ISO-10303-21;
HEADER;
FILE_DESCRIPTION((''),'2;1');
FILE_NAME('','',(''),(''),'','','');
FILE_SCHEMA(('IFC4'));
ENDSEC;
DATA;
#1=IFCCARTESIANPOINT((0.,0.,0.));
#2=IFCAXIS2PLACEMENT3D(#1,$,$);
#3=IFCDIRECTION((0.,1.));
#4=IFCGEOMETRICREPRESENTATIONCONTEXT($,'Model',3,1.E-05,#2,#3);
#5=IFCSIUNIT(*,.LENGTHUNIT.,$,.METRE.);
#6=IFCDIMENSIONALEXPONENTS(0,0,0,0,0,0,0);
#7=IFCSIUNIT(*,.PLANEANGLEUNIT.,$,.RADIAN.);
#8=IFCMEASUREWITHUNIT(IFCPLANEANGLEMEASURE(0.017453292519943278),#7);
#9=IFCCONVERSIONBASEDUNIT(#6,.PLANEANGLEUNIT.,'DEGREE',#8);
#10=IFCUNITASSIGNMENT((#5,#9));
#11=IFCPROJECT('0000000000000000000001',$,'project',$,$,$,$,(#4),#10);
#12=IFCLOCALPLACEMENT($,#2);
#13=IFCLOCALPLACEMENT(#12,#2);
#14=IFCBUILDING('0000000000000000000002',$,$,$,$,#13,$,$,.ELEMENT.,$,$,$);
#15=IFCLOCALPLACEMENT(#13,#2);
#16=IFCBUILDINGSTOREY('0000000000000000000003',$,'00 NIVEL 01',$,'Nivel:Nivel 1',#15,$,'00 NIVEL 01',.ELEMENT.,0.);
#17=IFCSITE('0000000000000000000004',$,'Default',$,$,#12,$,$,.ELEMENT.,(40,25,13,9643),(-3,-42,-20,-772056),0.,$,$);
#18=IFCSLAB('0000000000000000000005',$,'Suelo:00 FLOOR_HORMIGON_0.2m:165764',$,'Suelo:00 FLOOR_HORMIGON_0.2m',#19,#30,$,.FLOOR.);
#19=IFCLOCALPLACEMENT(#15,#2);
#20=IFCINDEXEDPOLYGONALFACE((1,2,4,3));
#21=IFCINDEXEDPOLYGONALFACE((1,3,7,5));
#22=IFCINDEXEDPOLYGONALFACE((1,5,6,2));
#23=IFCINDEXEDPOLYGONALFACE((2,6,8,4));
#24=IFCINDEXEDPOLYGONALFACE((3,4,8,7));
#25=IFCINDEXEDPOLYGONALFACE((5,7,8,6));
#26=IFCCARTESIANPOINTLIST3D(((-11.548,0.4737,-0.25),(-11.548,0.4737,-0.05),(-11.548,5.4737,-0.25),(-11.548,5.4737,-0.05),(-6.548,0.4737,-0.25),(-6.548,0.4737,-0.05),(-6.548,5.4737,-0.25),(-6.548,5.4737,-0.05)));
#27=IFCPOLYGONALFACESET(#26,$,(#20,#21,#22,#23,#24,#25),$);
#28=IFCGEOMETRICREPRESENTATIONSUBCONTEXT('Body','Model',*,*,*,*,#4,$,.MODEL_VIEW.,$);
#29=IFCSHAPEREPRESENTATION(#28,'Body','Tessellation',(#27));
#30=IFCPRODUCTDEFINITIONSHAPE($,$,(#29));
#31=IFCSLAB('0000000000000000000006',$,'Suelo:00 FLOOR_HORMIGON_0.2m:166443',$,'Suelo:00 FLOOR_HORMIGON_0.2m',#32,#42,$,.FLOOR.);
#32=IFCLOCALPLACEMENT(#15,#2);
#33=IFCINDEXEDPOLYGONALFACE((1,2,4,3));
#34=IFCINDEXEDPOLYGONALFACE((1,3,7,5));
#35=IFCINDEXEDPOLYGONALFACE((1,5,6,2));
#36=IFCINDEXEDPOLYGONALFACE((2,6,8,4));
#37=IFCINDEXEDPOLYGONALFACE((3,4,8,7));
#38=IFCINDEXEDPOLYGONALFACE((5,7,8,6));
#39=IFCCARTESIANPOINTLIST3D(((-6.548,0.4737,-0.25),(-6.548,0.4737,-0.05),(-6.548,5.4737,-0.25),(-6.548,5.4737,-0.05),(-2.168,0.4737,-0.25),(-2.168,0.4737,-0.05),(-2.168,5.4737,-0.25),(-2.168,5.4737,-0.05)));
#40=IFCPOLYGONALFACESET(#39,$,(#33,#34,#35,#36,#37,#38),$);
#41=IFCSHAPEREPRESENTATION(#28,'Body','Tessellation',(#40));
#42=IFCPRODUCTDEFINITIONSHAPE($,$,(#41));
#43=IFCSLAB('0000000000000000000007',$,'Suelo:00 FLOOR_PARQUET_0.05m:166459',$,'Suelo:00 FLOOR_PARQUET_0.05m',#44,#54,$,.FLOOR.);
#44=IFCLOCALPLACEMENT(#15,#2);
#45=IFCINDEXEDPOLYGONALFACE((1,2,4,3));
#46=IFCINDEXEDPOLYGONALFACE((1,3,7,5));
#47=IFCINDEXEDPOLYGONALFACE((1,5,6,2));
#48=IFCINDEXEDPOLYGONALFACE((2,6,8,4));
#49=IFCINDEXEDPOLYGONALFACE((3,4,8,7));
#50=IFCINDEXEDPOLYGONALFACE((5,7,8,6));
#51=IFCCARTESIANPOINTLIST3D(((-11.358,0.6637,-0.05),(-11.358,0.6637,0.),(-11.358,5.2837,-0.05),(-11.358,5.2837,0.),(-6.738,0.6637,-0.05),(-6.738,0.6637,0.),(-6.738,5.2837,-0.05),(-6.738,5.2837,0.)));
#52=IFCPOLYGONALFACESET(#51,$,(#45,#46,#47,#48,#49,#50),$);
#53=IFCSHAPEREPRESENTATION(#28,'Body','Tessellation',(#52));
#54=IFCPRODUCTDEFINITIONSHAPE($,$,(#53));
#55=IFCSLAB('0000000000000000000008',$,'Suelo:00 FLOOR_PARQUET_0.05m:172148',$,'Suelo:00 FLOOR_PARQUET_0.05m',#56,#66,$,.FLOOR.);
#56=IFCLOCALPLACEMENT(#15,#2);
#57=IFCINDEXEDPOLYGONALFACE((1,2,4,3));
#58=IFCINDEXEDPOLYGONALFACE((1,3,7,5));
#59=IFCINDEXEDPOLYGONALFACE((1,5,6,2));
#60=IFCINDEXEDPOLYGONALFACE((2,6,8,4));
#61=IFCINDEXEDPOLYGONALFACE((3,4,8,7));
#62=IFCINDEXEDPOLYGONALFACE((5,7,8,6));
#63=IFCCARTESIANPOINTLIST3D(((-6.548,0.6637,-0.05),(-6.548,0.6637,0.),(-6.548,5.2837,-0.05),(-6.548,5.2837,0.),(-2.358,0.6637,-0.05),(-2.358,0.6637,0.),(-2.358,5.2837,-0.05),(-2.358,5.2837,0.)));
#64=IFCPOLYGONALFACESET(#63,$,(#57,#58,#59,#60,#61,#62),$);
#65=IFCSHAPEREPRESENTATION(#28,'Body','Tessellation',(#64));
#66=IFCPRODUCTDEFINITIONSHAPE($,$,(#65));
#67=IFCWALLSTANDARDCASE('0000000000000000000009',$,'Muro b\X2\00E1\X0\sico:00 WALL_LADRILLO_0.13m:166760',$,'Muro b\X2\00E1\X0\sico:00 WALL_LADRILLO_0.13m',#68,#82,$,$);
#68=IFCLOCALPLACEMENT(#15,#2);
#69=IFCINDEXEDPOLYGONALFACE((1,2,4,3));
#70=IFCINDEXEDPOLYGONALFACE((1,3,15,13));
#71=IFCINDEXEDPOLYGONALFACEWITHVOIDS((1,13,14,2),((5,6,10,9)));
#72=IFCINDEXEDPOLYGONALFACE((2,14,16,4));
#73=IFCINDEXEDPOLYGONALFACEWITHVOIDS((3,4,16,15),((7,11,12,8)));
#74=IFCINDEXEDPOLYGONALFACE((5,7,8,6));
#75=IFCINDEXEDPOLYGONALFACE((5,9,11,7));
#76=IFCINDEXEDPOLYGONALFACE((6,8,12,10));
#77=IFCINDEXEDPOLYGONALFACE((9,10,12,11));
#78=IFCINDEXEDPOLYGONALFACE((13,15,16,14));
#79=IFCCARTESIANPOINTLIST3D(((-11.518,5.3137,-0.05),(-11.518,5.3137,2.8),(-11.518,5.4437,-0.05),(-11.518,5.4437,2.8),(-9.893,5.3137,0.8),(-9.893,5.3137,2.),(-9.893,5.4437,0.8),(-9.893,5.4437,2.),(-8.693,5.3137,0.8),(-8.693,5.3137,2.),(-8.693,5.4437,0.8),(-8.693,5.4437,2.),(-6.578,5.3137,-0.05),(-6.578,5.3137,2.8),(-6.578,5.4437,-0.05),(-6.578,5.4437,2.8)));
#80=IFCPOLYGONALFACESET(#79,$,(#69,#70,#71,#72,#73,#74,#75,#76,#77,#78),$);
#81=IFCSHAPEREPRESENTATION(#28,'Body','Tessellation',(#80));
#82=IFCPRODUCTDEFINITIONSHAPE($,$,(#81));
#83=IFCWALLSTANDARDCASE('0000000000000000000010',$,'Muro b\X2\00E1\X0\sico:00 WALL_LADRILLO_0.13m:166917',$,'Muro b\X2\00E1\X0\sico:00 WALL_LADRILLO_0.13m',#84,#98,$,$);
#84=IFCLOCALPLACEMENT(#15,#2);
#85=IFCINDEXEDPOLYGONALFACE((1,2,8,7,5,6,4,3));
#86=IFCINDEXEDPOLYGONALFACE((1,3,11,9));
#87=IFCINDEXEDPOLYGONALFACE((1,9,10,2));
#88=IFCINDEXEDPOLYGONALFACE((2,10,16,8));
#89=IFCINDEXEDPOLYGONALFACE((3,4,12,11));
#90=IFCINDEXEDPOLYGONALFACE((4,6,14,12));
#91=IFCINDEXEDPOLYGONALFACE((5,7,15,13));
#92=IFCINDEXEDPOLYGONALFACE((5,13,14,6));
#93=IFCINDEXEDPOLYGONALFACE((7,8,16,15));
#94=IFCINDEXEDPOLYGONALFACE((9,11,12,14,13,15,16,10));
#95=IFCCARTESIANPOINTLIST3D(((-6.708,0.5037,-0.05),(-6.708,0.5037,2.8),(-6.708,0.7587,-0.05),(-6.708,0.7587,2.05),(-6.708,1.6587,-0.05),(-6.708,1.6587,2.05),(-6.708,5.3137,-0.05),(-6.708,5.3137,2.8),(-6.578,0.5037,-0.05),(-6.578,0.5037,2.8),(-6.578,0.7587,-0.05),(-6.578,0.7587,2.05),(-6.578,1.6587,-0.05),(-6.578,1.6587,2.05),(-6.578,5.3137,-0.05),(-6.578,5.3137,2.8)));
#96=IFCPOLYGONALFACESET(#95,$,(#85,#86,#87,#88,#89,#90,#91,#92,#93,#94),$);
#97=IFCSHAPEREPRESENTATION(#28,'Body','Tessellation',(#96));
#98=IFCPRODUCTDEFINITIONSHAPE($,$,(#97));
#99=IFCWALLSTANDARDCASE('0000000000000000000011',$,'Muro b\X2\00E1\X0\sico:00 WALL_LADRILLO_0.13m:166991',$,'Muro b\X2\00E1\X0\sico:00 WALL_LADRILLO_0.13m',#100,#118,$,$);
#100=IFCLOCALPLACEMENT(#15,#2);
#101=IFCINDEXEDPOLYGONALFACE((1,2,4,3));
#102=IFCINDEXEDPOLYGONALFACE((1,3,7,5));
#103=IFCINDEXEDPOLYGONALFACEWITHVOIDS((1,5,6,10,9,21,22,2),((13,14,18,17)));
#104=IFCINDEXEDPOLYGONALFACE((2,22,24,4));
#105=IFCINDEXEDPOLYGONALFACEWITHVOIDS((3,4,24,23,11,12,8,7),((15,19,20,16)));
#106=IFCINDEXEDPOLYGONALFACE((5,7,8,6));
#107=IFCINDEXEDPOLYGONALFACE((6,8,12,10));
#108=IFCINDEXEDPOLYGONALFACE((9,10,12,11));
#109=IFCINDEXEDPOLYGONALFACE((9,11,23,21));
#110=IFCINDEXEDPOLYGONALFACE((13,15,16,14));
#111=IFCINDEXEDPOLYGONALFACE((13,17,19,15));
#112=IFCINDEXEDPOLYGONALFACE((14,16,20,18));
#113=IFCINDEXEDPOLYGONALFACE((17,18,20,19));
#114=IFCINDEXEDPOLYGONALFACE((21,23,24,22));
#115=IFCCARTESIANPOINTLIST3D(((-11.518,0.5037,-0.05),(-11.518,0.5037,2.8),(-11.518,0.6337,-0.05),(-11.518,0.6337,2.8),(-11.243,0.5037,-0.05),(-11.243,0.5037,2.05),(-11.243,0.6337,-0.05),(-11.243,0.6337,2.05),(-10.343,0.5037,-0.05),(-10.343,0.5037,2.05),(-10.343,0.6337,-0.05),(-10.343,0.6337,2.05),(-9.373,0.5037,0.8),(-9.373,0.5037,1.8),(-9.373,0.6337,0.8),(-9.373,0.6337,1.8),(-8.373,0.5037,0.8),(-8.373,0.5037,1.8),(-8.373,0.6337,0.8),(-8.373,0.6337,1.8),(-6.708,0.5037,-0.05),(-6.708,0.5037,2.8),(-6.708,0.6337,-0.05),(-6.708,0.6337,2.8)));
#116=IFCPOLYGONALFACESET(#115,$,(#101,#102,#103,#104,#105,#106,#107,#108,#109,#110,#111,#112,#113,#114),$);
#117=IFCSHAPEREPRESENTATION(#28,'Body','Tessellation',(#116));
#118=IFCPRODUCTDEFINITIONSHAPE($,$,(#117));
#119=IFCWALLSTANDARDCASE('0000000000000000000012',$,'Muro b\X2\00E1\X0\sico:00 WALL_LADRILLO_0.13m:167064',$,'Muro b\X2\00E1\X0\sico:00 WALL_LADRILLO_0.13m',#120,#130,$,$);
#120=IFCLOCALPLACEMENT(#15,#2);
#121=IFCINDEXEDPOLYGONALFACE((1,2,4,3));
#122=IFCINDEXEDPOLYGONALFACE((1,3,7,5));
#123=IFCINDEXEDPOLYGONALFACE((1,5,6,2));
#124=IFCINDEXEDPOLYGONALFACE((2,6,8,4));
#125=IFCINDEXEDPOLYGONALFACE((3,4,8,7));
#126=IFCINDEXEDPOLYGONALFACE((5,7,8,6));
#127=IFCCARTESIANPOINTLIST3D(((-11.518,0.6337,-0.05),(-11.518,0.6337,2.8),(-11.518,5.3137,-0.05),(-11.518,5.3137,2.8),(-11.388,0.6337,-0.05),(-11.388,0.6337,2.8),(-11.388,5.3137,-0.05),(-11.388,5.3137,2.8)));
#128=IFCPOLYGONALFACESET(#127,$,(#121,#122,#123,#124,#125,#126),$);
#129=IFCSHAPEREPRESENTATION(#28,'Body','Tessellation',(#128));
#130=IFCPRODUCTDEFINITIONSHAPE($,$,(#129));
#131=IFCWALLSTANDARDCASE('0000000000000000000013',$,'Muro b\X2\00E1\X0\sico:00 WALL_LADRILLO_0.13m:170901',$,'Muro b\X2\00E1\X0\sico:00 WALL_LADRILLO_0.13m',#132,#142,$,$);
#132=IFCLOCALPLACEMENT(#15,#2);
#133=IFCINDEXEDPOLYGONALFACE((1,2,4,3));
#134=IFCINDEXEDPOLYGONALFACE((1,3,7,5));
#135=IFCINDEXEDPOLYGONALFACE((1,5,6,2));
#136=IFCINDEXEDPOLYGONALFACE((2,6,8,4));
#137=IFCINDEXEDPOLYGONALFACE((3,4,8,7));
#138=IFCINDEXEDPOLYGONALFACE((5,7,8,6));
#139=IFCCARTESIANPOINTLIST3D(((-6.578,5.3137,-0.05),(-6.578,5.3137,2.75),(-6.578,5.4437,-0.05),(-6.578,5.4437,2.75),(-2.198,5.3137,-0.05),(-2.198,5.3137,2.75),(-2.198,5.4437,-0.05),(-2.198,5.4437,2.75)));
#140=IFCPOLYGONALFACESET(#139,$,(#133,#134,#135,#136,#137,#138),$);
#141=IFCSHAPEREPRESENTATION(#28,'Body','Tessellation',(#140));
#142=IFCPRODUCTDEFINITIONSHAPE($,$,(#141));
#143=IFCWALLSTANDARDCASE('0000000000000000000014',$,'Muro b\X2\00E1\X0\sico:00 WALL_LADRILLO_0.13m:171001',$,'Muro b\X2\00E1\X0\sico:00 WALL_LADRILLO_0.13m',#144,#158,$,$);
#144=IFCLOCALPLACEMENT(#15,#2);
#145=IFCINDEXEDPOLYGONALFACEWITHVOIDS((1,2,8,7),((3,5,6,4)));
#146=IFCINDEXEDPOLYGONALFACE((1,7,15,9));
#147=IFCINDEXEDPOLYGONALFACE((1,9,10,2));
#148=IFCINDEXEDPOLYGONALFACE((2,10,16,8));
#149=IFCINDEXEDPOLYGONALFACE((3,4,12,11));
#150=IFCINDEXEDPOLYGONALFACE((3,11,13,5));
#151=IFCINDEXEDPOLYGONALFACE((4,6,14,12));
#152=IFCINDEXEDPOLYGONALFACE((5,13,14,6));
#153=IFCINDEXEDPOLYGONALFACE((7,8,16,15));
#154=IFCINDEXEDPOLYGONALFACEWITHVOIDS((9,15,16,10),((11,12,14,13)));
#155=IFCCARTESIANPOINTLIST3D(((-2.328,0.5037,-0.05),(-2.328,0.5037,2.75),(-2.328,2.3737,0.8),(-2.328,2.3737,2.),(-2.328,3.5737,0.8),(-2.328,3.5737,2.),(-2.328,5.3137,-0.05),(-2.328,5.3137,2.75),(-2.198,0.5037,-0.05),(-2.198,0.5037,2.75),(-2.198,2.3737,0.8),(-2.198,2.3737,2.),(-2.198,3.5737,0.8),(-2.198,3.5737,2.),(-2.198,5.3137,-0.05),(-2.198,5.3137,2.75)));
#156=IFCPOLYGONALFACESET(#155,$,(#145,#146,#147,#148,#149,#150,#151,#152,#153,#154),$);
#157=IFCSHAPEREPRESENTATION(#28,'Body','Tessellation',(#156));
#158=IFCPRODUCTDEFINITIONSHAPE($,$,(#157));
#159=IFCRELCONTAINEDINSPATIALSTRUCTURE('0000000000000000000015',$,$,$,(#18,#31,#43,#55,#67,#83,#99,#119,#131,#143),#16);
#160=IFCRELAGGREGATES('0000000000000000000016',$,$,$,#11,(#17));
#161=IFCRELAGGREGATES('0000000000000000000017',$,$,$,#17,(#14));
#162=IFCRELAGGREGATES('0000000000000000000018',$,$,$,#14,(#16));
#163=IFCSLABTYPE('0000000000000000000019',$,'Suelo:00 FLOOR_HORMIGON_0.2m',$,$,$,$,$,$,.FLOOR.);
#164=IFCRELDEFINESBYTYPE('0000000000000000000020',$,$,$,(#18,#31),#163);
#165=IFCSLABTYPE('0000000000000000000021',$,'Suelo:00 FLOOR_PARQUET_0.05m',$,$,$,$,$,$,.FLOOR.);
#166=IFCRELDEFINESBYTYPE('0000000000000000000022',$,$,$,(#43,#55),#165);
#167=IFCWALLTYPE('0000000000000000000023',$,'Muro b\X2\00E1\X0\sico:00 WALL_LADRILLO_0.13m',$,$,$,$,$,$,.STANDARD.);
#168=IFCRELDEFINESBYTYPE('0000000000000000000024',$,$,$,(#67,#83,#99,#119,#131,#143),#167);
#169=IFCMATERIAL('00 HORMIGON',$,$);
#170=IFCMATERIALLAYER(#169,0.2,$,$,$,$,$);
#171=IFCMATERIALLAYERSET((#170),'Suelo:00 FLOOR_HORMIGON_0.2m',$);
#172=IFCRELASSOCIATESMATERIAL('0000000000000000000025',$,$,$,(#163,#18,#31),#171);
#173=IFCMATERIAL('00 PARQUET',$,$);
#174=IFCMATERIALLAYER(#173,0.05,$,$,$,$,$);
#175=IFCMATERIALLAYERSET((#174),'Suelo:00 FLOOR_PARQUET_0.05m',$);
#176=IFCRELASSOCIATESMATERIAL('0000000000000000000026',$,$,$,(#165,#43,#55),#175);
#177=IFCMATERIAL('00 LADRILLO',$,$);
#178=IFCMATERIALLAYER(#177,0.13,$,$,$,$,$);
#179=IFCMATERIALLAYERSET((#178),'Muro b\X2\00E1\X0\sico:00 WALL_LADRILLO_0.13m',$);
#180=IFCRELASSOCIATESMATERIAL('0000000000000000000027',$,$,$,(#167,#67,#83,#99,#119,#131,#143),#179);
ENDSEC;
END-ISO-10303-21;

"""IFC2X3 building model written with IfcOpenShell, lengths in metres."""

from ifc_helpers import new_model, entity, si_unit, converted_unit, direction, frame, frame_2d, origin, place, context, subcontext, project, spatial, rectangle, extrude, material, layer, layer_set, layer_usage, type_object, element, save


model = new_model("IFC2X3")

# Units and contexts
model_context = context("Model", 3, precision=1e-05, world=origin(), true_north=direction((0.0, 1.0)))
body_context = subcontext(model_context, "Body", "Model", "MODEL_VIEW")
ifc_project = project(units=[si_unit("LENGTHUNIT", "METRE"), converted_unit("PLANEANGLEUNIT", "DEGREE", entity("IfcPlaneAngleMeasure", 0.017453292519943278), si_unit("PLANEANGLEUNIT", "RADIAN"), dimensions=[0, 0, 0, 0, 0, 0, 0])], contexts=[model_context])

# Site, building, storey
site_placement = place(None, origin())
site = spatial("IfcSite", under=ifc_project, at=site_placement, Name="Default", CompositionType="ELEMENT", RefLatitude=(40, 25, 13, 9643), RefLongitude=(-3, -42, -20, -772056), RefElevation=0.0)
building_placement = place(site_placement, origin())
building = spatial("IfcBuilding", under=site, at=building_placement, CompositionType="ELEMENT")
storey_placement = place(building_placement, origin())
storey = spatial("IfcBuildingStorey", under=building, at=storey_placement, Name="00 NIVEL 01", ObjectType="Nivel:Nivel 1", LongName="00 NIVEL 01", CompositionType="ELEMENT", Elevation=0.0)

# Slabs
ifc_material_1 = material(Name="00 HORMIGON")
ifc_layer_1 = layer(ifc_material_1, 0.2)
ifc_layer_set_1 = layer_set([ifc_layer_1], Name="Suelo:00 FLOOR_HORMIGON_0.2m")
ifc_layer_usage_1 = layer_usage(ifc_layer_set_1, "AXIS3", "POSITIVE", 0.0)
slab_type_1 = type_object("IfcSlabType", Name="Suelo:00 FLOOR_HORMIGON_0.2m", PredefinedType="FLOOR", material=ifc_layer_set_1)
slab_1_placement = place(storey_placement, origin())
element("IfcSlab", 1, at=slab_1_placement, inside=storey, type_object=slab_type_1, material=ifc_layer_usage_1, Name="Suelo:00 FLOOR_HORMIGON_0.2m:165764", ObjectType="Suelo:00 FLOOR_HORMIGON_0.2m", PredefinedType="FLOOR", context=body_context, shape_type="SweptSolid", body=[
    extrude(rectangle(XDim=5.0, YDim=5.0, at=frame_2d((0.0, 0.0), x_axis=(1.0, 0.0))), frame((-9.048, 2.9737, -0.05), z_axis=(0.0, 0.0, -1.0), x_axis=(0.0, 1.0, 0.0)), (0.0, 0.0, 1.0), 0.2),
])
ifc_layer_usage_2 = layer_usage(ifc_layer_set_1, "AXIS3", "POSITIVE", 0.0)
slab_2_placement = place(storey_placement, origin())
element("IfcSlab", 2, at=slab_2_placement, inside=storey, type_object=slab_type_1, material=ifc_layer_usage_2, Name="Suelo:00 FLOOR_HORMIGON_0.2m:166443", ObjectType="Suelo:00 FLOOR_HORMIGON_0.2m", PredefinedType="FLOOR", context=body_context, shape_type="SweptSolid", body=[
    extrude(rectangle(XDim=5.0, YDim=4.38, at=frame_2d((0.0, 0.0), x_axis=(1.0, 0.0))), frame((-4.358, 2.9737, -0.05), z_axis=(0.0, 0.0, -1.0), x_axis=(0.0, 1.0, 0.0)), (0.0, 0.0, 1.0), 0.2),
])
ifc_material_2 = material(Name="00 PARQUET")
ifc_layer_2 = layer(ifc_material_2, 0.05)
ifc_layer_set_2 = layer_set([ifc_layer_2], Name="Suelo:00 FLOOR_PARQUET_0.05m")
ifc_layer_usage_3 = layer_usage(ifc_layer_set_2, "AXIS3", "POSITIVE", 0.0)
slab_type_2 = type_object("IfcSlabType", Name="Suelo:00 FLOOR_PARQUET_0.05m", PredefinedType="FLOOR", material=ifc_layer_set_2)
slab_3_placement = place(storey_placement, origin())
element("IfcSlab", 3, at=slab_3_placement, inside=storey, type_object=slab_type_2, material=ifc_layer_usage_3, Name="Suelo:00 FLOOR_PARQUET_0.05m:166459", ObjectType="Suelo:00 FLOOR_PARQUET_0.05m", PredefinedType="FLOOR", context=body_context, shape_type="SweptSolid", body=[
    extrude(rectangle(XDim=4.62, YDim=4.62, at=frame_2d((0.0, 0.0), x_axis=(1.0, 0.0))), frame((-9.048, 2.9737, 0.0), z_axis=(0.0, 0.0, -1.0), x_axis=(0.0, 1.0, 0.0)), (0.0, 0.0, 1.0), 0.05),
])
ifc_layer_usage_4 = layer_usage(ifc_layer_set_2, "AXIS3", "POSITIVE", 0.0)
slab_4_placement = place(storey_placement, origin())
element("IfcSlab", 4, at=slab_4_placement, inside=storey, type_object=slab_type_2, material=ifc_layer_usage_4, Name="Suelo:00 FLOOR_PARQUET_0.05m:172148", ObjectType="Suelo:00 FLOOR_PARQUET_0.05m", PredefinedType="FLOOR", context=body_context, shape_type="SweptSolid", body=[
    extrude(rectangle(XDim=4.62, YDim=4.19, at=frame_2d((0.0, 0.0), x_axis=(1.0, 0.0))), frame((-4.453, 2.9737, 0.0), z_axis=(0.0, 0.0, -1.0), x_axis=(0.0, 1.0, 0.0)), (0.0, 0.0, 1.0), 0.05),
])

# Walls, openings
ifc_material_3 = material(Name="00 LADRILLO")
ifc_layer_3 = layer(ifc_material_3, 0.13)
ifc_layer_set_3 = layer_set([ifc_layer_3], Name="Muro básico:00 WALL_LADRILLO_0.13m")
ifc_layer_usage_5 = layer_usage(ifc_layer_set_3, "AXIS2", "NEGATIVE", 0.065)
wall_type_1 = type_object("IfcWallType", Name="Muro básico:00 WALL_LADRILLO_0.13m", PredefinedType="STANDARD", material=ifc_layer_set_3)
wall_1_placement = place(storey_placement, frame((-11.518, 5.3787, -0.05)))
wall_1 = element("IfcWallStandardCase", 5, at=wall_1_placement, inside=storey, type_object=wall_type_1, material=ifc_layer_usage_5, Name="Muro básico:00 WALL_LADRILLO_0.13m:166760", ObjectType="Muro básico:00 WALL_LADRILLO_0.13m", context=body_context, shape_type="SweptSolid", body=[
    extrude(rectangle(XDim=4.94, YDim=0.13, at=frame_2d((2.47, 0.0), x_axis=(-1.0, 0.0))), origin(), (0.0, 0.0, 1.0), 2.85),
])
opening_1_placement = place(wall_1_placement, frame((1.625, -0.065, 0.85)))
element("IfcOpeningElement", 6, at=opening_1_placement, cuts=wall_1, ObjectType="Opening", context=body_context, shape_type="SweptSolid", body=[
    extrude(rectangle(XDim=1.2, YDim=1.2, at=frame_2d((0.6, 0.6), x_axis=(1.0, 0.0))), frame((0.0, 0.0, 0.0), z_axis=(0.0, 1.0, 0.0), x_axis=(0.0, 0.0, 1.0)), (0.0, 0.0, 1.0), 0.13),
])
ifc_layer_usage_6 = layer_usage(ifc_layer_set_3, "AXIS2", "NEGATIVE", 0.065)
wall_2_placement = place(storey_placement, frame((-6.643, 5.3137, -0.05), z_axis=(0.0, 0.0, 1.0), x_axis=(0.0, -1.0, 0.0)))
wall_2 = element("IfcWallStandardCase", 7, at=wall_2_placement, inside=storey, type_object=wall_type_1, material=ifc_layer_usage_6, Name="Muro básico:00 WALL_LADRILLO_0.13m:166917", ObjectType="Muro básico:00 WALL_LADRILLO_0.13m", context=body_context, shape_type="SweptSolid", body=[
    extrude(rectangle(XDim=4.81, YDim=0.13, at=frame_2d((2.405, 0.0), x_axis=(-1.0, 0.0))), origin(), (0.0, 0.0, 1.0), 2.85),
])
opening_2_placement = place(wall_2_placement, frame((3.655, -0.065, 0.0)))
element("IfcOpeningElement", 8, at=opening_2_placement, cuts=wall_2, ObjectType="Opening", context=body_context, shape_type="SweptSolid", body=[
    extrude(rectangle(XDim=2.1, YDim=0.9, at=frame_2d((1.05, 0.45), x_axis=(1.0, 0.0))), frame((0.0, 0.0, 0.0), z_axis=(0.0, 1.0, 0.0), x_axis=(0.0, 0.0, 1.0)), (0.0, 0.0, 1.0), 0.13),
])

# Wall, openings
ifc_layer_usage_7 = layer_usage(ifc_layer_set_3, "AXIS2", "NEGATIVE", 0.065)
wall_3_placement = place(storey_placement, frame((-6.708, 0.5687, -0.05), z_axis=(0.0, 0.0, 1.0), x_axis=(-1.0, 0.0, 0.0)))
wall_3 = element("IfcWallStandardCase", 9, at=wall_3_placement, inside=storey, type_object=wall_type_1, material=ifc_layer_usage_7, Name="Muro básico:00 WALL_LADRILLO_0.13m:166991", ObjectType="Muro básico:00 WALL_LADRILLO_0.13m", context=body_context, shape_type="SweptSolid", body=[
    extrude(rectangle(XDim=4.81, YDim=0.13, at=frame_2d((2.405, 0.0), x_axis=(1.0, 0.0))), origin(), (0.0, 0.0, 1.0), 2.85),
])
opening_3_placement = place(wall_3_placement, frame((4.535, 0.065, 0.0)))
element("IfcOpeningElement", 10, at=opening_3_placement, cuts=wall_3, ObjectType="Opening", context=body_context, shape_type="SweptSolid", body=[
    extrude(rectangle(XDim=2.1, YDim=0.9, at=frame_2d((1.05, 0.45), x_axis=(1.0, 0.0))), frame((0.0, 0.0, 0.0), z_axis=(0.0, -1.0, 0.0), x_axis=(0.0, 0.0, 1.0)), (0.0, 0.0, 1.0), 0.13),
])
opening_4_placement = place(wall_3_placement, frame((2.665, 0.065, 0.85)))
element("IfcOpeningElement", 11, at=opening_4_placement, cuts=wall_3, ObjectType="Opening", context=body_context, shape_type="SweptSolid", body=[
    extrude(rectangle(XDim=1.0, YDim=1.0, at=frame_2d((0.5, 0.5), x_axis=(1.0, 0.0))), frame((0.0, 0.0, 0.0), z_axis=(0.0, -1.0, 0.0), x_axis=(0.0, 0.0, 1.0)), (0.0, 0.0, 1.0), 0.13),
])

# Walls
ifc_layer_usage_8 = layer_usage(ifc_layer_set_3, "AXIS2", "NEGATIVE", 0.065)
wall_4_placement = place(storey_placement, frame((-11.453, 0.6337, -0.05), z_axis=(0.0, 0.0, 1.0), x_axis=(0.0, 1.0, 0.0)))
element("IfcWallStandardCase", 12, at=wall_4_placement, inside=storey, type_object=wall_type_1, material=ifc_layer_usage_8, Name="Muro básico:00 WALL_LADRILLO_0.13m:167064", ObjectType="Muro básico:00 WALL_LADRILLO_0.13m", context=body_context, shape_type="SweptSolid", body=[
    extrude(rectangle(XDim=4.68, YDim=0.13, at=frame_2d((2.34, 0.0), x_axis=(-1.0, 0.0))), origin(), (0.0, 0.0, 1.0), 2.85),
])
ifc_layer_usage_9 = layer_usage(ifc_layer_set_3, "AXIS2", "NEGATIVE", 0.065)
wall_5_placement = place(storey_placement, frame((-6.578, 5.3787, -0.05)))
element("IfcWallStandardCase", 13, at=wall_5_placement, inside=storey, type_object=wall_type_1, material=ifc_layer_usage_9, Name="Muro básico:00 WALL_LADRILLO_0.13m:170901", ObjectType="Muro básico:00 WALL_LADRILLO_0.13m", context=body_context, shape_type="SweptSolid", body=[
    extrude(rectangle(XDim=4.38, YDim=0.13, at=frame_2d((2.19, 0.0), x_axis=(-1.0, 0.0))), origin(), (0.0, 0.0, 1.0), 2.8),
])

# Wall, opening
ifc_layer_usage_10 = layer_usage(ifc_layer_set_3, "AXIS2", "NEGATIVE", 0.065)
wall_6_placement = place(storey_placement, frame((-2.263, 5.3137, -0.05), z_axis=(0.0, 0.0, 1.0), x_axis=(0.0, -1.0, 0.0)))
wall_6 = element("IfcWallStandardCase", 14, at=wall_6_placement, inside=storey, type_object=wall_type_1, material=ifc_layer_usage_10, Name="Muro básico:00 WALL_LADRILLO_0.13m:171001", ObjectType="Muro básico:00 WALL_LADRILLO_0.13m", context=body_context, shape_type="SweptSolid", body=[
    extrude(rectangle(XDim=4.81, YDim=0.13, at=frame_2d((2.405, 0.0), x_axis=(-1.0, 0.0))), origin(), (0.0, 0.0, 1.0), 2.8),
])
opening_5_placement = place(wall_6_placement, frame((2.94, 0.065, 0.85)))
element("IfcOpeningElement", 15, at=opening_5_placement, cuts=wall_6, ObjectType="Opening", context=body_context, shape_type="SweptSolid", body=[
    extrude(rectangle(XDim=1.2, YDim=1.2, at=frame_2d((0.6, 0.6), x_axis=(1.0, 0.0))), frame((0.0, 0.0, 0.0), z_axis=(0.0, -1.0, 0.0), x_axis=(0.0, 0.0, 1.0)), (0.0, 0.0, 1.0), 0.13),
])

save(model, "model.ifc")
